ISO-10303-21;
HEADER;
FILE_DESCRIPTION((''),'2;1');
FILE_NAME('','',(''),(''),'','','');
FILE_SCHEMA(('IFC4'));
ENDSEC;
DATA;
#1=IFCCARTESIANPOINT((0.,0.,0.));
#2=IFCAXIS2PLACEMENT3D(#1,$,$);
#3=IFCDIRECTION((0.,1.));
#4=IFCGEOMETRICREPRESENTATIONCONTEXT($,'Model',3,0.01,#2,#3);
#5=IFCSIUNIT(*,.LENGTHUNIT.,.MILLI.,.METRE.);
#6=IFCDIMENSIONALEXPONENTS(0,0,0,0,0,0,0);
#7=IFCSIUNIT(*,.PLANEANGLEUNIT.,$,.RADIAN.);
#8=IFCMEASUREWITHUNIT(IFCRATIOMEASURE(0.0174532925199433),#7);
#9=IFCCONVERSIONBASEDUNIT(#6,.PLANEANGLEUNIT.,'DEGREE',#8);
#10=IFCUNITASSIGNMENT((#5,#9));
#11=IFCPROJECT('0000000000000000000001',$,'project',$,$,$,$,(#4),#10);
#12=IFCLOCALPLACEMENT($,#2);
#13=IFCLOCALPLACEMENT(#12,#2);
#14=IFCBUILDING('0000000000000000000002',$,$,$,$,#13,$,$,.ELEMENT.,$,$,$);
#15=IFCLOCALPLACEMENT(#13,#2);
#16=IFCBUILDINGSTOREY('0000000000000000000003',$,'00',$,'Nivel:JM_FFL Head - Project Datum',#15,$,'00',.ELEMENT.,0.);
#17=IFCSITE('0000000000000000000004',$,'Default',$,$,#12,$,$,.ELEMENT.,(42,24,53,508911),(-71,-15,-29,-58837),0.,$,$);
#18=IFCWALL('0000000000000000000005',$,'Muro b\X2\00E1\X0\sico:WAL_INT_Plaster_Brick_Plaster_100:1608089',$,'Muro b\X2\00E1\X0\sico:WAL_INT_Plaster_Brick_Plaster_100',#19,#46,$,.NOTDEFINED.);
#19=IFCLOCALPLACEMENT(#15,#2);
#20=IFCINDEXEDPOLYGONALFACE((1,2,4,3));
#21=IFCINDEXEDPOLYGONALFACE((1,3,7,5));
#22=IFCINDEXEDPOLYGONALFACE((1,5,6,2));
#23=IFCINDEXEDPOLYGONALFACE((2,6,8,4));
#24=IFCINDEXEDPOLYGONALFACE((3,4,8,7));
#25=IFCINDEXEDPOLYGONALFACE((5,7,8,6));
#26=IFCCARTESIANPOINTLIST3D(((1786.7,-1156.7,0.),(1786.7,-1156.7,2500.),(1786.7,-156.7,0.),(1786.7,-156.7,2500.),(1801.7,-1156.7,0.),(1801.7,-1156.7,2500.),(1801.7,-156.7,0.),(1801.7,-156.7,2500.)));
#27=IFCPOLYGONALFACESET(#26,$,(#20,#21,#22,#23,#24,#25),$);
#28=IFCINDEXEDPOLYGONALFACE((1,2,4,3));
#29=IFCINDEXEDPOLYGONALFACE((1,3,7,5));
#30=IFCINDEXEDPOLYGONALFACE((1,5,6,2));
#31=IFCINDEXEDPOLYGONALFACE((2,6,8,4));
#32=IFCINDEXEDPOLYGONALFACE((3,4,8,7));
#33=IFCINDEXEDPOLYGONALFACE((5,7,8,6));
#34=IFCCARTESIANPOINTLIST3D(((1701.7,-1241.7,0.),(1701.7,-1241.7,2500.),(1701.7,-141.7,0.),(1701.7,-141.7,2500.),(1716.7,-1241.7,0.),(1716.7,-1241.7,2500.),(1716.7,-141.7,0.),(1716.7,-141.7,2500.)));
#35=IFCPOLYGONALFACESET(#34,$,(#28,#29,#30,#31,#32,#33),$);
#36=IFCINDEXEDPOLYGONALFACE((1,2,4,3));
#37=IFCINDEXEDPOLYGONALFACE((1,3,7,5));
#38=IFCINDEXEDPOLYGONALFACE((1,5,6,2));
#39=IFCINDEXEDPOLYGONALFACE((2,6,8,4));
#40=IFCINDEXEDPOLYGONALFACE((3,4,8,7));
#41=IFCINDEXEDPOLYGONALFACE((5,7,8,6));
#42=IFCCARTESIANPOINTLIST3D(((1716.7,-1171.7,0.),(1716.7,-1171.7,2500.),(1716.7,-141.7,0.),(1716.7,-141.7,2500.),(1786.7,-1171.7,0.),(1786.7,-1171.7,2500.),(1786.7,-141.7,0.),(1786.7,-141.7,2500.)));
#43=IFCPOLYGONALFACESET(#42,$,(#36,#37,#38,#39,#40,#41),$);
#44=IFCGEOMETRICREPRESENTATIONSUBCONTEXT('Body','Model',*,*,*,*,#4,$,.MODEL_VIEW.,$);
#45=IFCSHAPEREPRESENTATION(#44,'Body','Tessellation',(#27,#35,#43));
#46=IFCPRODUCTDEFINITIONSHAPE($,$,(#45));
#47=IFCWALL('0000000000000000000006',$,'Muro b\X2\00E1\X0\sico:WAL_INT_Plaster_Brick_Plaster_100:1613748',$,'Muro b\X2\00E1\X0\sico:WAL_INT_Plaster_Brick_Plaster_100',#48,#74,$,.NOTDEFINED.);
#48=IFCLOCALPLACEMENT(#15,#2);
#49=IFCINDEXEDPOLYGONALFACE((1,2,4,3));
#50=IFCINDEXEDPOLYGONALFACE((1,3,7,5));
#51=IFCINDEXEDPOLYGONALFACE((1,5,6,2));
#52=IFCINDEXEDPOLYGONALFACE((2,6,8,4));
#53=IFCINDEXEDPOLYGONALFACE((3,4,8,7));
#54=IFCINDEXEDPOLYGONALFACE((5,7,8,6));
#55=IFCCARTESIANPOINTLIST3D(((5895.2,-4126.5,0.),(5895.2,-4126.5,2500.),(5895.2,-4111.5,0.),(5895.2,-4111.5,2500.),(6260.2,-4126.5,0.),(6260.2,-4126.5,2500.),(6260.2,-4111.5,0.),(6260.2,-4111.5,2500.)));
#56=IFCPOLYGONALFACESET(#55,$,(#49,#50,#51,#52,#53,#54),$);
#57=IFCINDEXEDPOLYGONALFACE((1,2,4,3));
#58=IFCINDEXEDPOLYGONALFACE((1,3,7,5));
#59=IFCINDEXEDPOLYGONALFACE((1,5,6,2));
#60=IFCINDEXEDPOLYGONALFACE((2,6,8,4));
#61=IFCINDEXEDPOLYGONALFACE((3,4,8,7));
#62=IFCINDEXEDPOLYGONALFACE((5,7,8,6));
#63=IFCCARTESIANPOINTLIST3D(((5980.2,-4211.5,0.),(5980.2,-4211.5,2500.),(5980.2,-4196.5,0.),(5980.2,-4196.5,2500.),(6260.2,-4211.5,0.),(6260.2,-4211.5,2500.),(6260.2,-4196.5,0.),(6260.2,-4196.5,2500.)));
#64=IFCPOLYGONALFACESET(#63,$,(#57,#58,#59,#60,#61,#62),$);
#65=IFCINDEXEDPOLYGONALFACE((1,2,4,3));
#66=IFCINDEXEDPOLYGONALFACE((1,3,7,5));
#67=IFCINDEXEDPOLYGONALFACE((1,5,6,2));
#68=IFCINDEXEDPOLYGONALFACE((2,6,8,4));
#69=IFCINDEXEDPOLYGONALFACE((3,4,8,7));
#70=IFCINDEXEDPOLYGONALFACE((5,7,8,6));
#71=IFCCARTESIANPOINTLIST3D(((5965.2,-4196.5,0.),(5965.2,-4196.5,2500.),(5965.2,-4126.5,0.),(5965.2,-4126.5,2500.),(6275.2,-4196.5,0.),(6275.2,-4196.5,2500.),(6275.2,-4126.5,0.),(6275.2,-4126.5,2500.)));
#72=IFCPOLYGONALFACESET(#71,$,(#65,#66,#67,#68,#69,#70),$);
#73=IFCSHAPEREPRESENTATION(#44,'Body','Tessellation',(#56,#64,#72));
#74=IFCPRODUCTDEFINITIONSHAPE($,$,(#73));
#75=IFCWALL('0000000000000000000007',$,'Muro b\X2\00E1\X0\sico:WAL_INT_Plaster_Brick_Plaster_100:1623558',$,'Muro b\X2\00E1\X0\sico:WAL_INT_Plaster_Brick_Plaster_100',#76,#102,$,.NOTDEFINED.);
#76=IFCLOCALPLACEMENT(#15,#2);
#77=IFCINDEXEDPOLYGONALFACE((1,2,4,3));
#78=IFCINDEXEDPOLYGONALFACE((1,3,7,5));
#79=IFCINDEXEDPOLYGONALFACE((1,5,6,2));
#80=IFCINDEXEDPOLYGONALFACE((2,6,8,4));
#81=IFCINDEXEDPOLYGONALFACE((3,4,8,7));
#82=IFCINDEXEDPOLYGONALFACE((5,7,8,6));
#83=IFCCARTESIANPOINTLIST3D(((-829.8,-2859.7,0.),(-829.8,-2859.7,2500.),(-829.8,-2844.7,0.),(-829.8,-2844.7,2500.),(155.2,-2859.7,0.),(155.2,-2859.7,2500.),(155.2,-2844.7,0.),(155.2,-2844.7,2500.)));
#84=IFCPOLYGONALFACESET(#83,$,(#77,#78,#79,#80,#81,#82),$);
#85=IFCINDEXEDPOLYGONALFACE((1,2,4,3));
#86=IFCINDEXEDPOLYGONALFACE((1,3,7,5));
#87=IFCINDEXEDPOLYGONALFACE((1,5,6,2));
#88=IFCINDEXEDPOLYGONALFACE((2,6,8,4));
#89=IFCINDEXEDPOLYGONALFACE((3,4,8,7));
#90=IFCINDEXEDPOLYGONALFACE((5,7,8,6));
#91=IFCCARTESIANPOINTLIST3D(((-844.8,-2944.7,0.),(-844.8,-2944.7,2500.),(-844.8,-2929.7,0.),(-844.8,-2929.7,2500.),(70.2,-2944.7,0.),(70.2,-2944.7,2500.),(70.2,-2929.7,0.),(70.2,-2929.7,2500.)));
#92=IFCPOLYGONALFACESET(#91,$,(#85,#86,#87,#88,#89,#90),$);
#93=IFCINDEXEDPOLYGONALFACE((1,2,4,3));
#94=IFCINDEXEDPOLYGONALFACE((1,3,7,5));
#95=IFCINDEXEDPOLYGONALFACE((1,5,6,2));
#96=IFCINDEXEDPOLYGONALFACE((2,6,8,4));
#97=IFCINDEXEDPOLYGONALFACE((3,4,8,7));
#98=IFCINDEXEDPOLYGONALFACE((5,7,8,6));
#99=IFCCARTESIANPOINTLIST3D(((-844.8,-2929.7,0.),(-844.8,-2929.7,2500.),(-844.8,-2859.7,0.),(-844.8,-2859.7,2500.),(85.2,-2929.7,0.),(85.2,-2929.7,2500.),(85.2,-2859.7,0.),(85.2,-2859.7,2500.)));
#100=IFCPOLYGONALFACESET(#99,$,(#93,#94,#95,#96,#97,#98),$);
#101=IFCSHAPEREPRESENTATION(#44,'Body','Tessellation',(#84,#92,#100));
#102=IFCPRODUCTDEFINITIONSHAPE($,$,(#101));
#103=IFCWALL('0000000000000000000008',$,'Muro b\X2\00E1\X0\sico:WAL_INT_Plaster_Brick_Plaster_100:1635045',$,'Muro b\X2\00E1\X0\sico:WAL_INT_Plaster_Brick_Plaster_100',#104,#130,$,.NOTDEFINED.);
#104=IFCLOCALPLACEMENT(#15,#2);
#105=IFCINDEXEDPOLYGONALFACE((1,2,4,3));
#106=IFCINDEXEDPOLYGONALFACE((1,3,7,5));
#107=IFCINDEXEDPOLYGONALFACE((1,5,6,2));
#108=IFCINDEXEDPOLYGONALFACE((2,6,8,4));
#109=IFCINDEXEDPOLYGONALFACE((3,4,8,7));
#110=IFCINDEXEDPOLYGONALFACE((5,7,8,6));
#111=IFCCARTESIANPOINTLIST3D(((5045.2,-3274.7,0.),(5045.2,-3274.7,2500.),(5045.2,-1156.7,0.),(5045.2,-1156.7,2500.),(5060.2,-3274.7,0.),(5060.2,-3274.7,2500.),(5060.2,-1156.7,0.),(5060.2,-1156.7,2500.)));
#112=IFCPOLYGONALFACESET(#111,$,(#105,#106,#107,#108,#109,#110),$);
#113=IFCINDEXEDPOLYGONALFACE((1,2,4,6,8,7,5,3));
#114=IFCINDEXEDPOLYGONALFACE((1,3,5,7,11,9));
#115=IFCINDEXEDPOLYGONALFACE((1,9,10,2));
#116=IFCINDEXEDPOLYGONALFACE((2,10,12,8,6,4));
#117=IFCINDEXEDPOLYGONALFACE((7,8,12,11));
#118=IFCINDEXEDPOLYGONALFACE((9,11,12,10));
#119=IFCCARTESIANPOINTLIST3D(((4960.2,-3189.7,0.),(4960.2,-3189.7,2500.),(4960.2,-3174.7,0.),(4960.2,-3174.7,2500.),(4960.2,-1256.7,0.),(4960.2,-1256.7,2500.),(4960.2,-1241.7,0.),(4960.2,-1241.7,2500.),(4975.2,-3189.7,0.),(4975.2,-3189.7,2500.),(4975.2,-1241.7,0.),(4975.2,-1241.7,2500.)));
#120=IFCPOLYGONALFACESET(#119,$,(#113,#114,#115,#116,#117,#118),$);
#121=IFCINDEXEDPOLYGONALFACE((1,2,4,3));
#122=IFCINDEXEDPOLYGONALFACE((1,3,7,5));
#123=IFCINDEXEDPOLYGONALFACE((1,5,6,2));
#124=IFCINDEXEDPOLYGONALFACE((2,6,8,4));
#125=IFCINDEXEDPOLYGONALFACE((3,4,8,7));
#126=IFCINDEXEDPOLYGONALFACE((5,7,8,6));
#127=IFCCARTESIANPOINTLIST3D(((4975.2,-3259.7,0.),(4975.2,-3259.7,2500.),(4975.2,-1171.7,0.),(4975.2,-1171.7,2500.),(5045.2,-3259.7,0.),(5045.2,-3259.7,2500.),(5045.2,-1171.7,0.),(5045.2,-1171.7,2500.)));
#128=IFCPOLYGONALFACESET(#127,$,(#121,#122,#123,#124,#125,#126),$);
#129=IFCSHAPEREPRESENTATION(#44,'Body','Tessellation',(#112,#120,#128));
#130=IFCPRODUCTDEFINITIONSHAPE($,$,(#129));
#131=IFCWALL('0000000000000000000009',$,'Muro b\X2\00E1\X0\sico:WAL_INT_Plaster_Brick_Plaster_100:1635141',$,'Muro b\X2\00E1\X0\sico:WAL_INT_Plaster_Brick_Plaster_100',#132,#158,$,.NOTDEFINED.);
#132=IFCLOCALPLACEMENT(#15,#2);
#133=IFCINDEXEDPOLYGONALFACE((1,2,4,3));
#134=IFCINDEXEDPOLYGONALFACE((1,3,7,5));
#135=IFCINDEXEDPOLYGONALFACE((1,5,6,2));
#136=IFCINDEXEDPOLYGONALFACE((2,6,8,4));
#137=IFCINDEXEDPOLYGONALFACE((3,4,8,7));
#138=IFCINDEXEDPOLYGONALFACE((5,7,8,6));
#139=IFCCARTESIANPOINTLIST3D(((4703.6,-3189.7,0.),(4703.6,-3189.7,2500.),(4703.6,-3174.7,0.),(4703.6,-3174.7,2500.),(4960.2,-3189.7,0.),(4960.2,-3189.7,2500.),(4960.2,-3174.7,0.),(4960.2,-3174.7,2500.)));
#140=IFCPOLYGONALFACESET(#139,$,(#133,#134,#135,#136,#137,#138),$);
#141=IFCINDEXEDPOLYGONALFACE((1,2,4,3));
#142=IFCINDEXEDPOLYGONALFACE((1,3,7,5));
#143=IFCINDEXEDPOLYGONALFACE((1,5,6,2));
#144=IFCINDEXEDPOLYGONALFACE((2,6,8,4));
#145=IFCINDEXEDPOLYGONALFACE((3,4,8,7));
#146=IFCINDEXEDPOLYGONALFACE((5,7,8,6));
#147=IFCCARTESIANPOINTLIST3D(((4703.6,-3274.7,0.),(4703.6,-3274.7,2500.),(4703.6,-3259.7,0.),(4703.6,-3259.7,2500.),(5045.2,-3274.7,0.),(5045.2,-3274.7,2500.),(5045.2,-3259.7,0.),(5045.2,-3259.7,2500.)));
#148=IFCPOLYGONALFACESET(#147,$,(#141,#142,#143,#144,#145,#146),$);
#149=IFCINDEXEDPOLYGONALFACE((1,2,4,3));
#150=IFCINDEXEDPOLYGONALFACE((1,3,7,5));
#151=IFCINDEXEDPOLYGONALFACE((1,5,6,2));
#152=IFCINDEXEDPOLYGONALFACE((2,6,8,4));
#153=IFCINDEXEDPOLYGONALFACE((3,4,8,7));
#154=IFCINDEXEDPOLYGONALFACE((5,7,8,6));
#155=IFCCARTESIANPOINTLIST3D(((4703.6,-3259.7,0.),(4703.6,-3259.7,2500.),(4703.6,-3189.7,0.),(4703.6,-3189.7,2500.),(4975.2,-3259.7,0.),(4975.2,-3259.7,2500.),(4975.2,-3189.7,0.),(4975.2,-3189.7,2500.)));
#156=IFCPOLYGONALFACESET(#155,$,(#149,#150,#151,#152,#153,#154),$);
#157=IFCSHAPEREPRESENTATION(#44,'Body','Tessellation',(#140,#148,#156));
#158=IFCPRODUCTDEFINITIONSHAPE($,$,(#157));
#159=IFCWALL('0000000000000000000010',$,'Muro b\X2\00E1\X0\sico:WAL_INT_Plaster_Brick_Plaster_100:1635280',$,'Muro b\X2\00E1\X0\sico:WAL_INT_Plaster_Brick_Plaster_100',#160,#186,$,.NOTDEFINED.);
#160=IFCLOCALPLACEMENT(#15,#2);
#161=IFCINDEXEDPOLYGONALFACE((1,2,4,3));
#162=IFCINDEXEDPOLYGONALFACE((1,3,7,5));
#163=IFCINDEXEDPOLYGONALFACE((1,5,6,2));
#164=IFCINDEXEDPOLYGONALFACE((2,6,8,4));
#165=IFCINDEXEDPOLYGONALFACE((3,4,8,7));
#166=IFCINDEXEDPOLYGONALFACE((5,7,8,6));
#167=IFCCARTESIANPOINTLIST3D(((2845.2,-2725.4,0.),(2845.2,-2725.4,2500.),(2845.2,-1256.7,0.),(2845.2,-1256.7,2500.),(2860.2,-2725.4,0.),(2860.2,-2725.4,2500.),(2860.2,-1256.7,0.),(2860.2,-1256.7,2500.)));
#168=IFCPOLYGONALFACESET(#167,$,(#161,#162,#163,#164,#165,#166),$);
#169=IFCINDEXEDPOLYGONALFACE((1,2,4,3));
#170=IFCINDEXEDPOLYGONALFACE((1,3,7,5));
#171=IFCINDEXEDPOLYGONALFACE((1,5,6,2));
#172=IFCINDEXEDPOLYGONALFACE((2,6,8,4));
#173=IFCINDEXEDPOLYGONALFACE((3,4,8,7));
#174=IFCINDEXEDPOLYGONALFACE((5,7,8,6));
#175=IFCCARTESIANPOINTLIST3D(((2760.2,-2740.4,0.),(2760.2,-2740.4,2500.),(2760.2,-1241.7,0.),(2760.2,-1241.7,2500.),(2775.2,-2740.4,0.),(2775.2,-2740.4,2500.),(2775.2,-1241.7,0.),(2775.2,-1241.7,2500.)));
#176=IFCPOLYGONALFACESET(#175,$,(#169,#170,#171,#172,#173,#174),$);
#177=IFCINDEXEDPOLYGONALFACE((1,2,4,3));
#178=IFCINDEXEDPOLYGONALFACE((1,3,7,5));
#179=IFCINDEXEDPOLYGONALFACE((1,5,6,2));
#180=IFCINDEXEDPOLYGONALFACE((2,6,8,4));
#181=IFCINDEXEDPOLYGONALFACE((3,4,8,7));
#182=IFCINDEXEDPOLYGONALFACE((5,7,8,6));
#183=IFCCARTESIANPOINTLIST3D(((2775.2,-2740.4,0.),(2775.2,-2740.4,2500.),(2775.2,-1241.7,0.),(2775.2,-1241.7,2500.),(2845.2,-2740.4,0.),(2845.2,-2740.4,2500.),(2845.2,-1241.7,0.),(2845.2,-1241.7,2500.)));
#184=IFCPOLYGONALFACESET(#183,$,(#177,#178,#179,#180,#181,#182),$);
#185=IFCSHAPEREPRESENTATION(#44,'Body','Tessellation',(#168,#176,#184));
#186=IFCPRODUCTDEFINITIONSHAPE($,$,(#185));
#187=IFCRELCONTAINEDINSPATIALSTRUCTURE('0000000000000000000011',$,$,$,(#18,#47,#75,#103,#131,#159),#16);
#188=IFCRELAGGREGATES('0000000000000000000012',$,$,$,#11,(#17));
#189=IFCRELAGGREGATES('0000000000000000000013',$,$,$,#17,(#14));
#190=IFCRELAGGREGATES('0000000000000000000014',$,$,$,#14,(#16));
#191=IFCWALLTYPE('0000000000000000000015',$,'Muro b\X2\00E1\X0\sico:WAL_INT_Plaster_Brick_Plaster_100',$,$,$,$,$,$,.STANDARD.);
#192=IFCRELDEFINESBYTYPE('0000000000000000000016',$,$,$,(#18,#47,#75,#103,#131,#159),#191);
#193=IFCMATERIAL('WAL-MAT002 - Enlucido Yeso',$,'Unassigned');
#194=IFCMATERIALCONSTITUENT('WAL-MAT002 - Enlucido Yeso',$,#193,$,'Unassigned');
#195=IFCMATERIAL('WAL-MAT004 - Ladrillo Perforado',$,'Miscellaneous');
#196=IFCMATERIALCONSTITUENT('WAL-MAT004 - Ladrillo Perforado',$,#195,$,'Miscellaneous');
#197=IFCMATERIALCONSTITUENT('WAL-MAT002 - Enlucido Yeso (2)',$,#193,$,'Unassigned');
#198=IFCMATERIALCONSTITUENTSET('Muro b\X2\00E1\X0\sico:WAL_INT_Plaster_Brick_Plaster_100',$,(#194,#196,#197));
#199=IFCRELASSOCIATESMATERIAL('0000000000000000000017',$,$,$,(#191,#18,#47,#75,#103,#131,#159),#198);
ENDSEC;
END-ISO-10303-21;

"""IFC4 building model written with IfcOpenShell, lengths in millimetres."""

from ifc_helpers import new_model, entity, si_unit, converted_unit, direction, frame, origin, place, context, subcontext, project, spatial, indexed_curve, outline, extrude, material, constituent, constituent_set, type_object, element, save


model = new_model("IFC4")

# Units and contexts
model_context = context("Model", 3, precision=0.01, world=origin(), true_north=direction((0.0, 1.0)))
body_context = subcontext(model_context, "Body", "Model", "MODEL_VIEW")
ifc_project = project(units=[si_unit("LENGTHUNIT", "METRE", prefix="MILLI"), converted_unit("PLANEANGLEUNIT", "DEGREE", entity("IfcRatioMeasure", 0.0174532925199433), si_unit("PLANEANGLEUNIT", "RADIAN"), dimensions=[0, 0, 0, 0, 0, 0, 0])], contexts=[model_context])

# Site, building, storey
site_placement = place(None, origin())
site = spatial("IfcSite", under=ifc_project, at=site_placement, Name="Default", CompositionType="ELEMENT", RefLatitude=(42, 24, 53, 508911), RefLongitude=(-71, -15, -29, -58837), RefElevation=0.0)
building_placement = place(site_placement, origin())
building = spatial("IfcBuilding", under=site, at=building_placement, CompositionType="ELEMENT")
storey_placement = place(building_placement, origin())
storey = spatial("IfcBuildingStorey", under=building, at=storey_placement, Name="00", ObjectType="Nivel:JM_FFL Head - Project Datum", LongName="00", CompositionType="ELEMENT", Elevation=0.0)

# Walls
ifc_material_1 = material(Name="WAL-MAT004 - Ladrillo Perforado", Category="Miscellaneous")
ifc_material_2 = material(Name="WAL-MAT002 - Enlucido Yeso", Category="Unassigned")
ifc_constituent_1 = constituent(ifc_material_2, Name="WAL-MAT002 - Enlucido Yeso", Category="Unassigned")
ifc_constituent_2 = constituent(ifc_material_1, Name="WAL-MAT004 - Ladrillo Perforado", Category="Miscellaneous")
ifc_constituent_3 = constituent(ifc_material_2, Name="WAL-MAT002 - Enlucido Yeso (2)", Category="Unassigned")
ifc_constituent_set_1 = constituent_set(constituents=[ifc_constituent_1, ifc_constituent_2, ifc_constituent_3], Name="Muro básico:WAL_INT_Plaster_Brick_Plaster_100")
wall_type_1 = type_object("IfcWallType", Name="Muro básico:WAL_INT_Plaster_Brick_Plaster_100", PredefinedType="STANDARD", material=ifc_constituent_set_1)
wall_1_placement = place(storey_placement, frame((1751.7, -1156.7, 0.0), z_axis=(0.0, 0.0, 1.0), x_axis=(0.0, 1.0, 0.0)))
element("IfcWall", 1, at=wall_1_placement, inside=storey, type_object=wall_type_1, material=ifc_constituent_set_1, Name="Muro básico:WAL_INT_Plaster_Brick_Plaster_100:1608089", ObjectType="Muro básico:WAL_INT_Plaster_Brick_Plaster_100", PredefinedType="NOTDEFINED", context=body_context, shape_type="SweptSolid", body=[
    extrude(outline(indexed_curve([(-7.5, -500.0), (7.5, -500.0), (7.5, 500.0), (-7.5, 500.0), (-7.5, -500.0)], self_intersect=False)), frame((500.0, -42.5, 0.0), z_axis=(0.0, 0.0, 1.0), x_axis=(0.0, 1.0, 0.0)), (0.0, 0.0, 1.0), 2500.0),
    extrude(outline(indexed_curve([(-7.5, -550.0), (7.5, -550.0), (7.5, 550.0), (-7.5, 550.0), (-7.5, -550.0)], self_intersect=False)), frame((465.0, 42.5, 0.0), z_axis=(0.0, 0.0, 1.0), x_axis=(0.0, -1.0, 0.0)), (0.0, 0.0, 1.0), 2500.0),
    extrude(outline(indexed_curve([(-515.0, -35.0), (515.0, -35.0), (515.0, 35.0), (-515.0, 35.0), (-515.0, -35.0)], self_intersect=False)), frame((500.0, 0.0, 0.0)), (0.0, 0.0, 1.0), 2500.0),
])
wall_2_placement = place(storey_placement, frame((5980.2, -4161.5, 0.0)))
element("IfcWall", 2, at=wall_2_placement, inside=storey, type_object=wall_type_1, material=ifc_constituent_set_1, Name="Muro básico:WAL_INT_Plaster_Brick_Plaster_100:1613748", ObjectType="Muro básico:WAL_INT_Plaster_Brick_Plaster_100", PredefinedType="NOTDEFINED", context=body_context, shape_type="SweptSolid", body=[
    extrude(outline(indexed_curve([(-7.5, -182.5), (7.5, -182.5), (7.5, 182.5), (-7.5, 182.5), (-7.5, -182.5)], self_intersect=False)), frame((97.5, 42.5, 0.0), z_axis=(0.0, 0.0, 1.0), x_axis=(0.0, -1.0, 0.0)), (0.0, 0.0, 1.0), 2500.0),
    extrude(outline(indexed_curve([(-7.5, -140.0), (7.5, -140.0), (7.5, 140.0), (-7.5, 140.0), (-7.5, -140.0)], self_intersect=False)), frame((140.0, -42.5, 0.0), z_axis=(0.0, 0.0, 1.0), x_axis=(0.0, 1.0, 0.0)), (0.0, 0.0, 1.0), 2500.0),
    extrude(outline(indexed_curve([(-155.0, -35.0), (155.0, -35.0), (155.0, 35.0), (-155.0, 35.0), (-155.0, -35.0)], self_intersect=False)), frame((140.0, 0.0, 0.0)), (0.0, 0.0, 1.0), 2500.0),
])
wall_3_placement = place(storey_placement, frame((70.2, -2894.7, 0.0), z_axis=(0.0, 0.0, 1.0), x_axis=(-1.0, 0.0, 0.0)))
element("IfcWall", 3, at=wall_3_placement, inside=storey, type_object=wall_type_1, material=ifc_constituent_set_1, Name="Muro básico:WAL_INT_Plaster_Brick_Plaster_100:1623558", ObjectType="Muro básico:WAL_INT_Plaster_Brick_Plaster_100", PredefinedType="NOTDEFINED", context=body_context, shape_type="SweptSolid", body=[
    extrude(outline(indexed_curve([(-7.5, -492.5), (7.5, -492.5), (7.5, 492.5), (-7.5, 492.5), (-7.5, -492.5)], self_intersect=False)), frame((407.5, -42.5, 0.0), z_axis=(0.0, 0.0, 1.0), x_axis=(0.0, 1.0, 0.0)), (0.0, 0.0, 1.0), 2500.0),
    extrude(outline(indexed_curve([(-7.5, -457.5), (7.5, -457.5), (7.5, 457.5), (-7.5, 457.5), (-7.5, -457.5)], self_intersect=False)), frame((457.5, 42.5, 0.0), z_axis=(0.0, 0.0, 1.0), x_axis=(0.0, -1.0, 0.0)), (0.0, 0.0, 1.0), 2500.0),
    extrude(outline(indexed_curve([(-465.0, -35.0), (465.0, -35.0), (465.0, 35.0), (-465.0, 35.0), (-465.0, -35.0)], self_intersect=False)), frame((450.0, 0.0, 0.0)), (0.0, 0.0, 1.0), 2500.0),
])
wall_4_placement = place(storey_placement, frame((5010.2, -3274.7, 0.0), z_axis=(0.0, 0.0, 1.0), x_axis=(0.0, 1.0, 0.0)))
element("IfcWall", 4, at=wall_4_placement, inside=storey, type_object=wall_type_1, material=ifc_constituent_set_1, Name="Muro básico:WAL_INT_Plaster_Brick_Plaster_100:1635045", ObjectType="Muro básico:WAL_INT_Plaster_Brick_Plaster_100", PredefinedType="NOTDEFINED", context=body_context, shape_type="SweptSolid", body=[
    extrude(outline(indexed_curve([(-7.5, -1059.0), (7.5, -1059.0), (7.5, 1059.0), (-7.5, 1059.0), (-7.5, -1059.0)], self_intersect=False)), frame((1059.0, -42.5, 0.0), z_axis=(0.0, 0.0, 1.0), x_axis=(0.0, 1.0, 0.0)), (0.0, 0.0, 1.0), 2500.0),
    extrude(outline(indexed_curve([(-959.0, -5.0), (959.0, -5.0), (974.0, -5.0), (974.0, 10.0), (-974.0, 10.0), (-974.0, -5.0), (-959.0, -5.0)], self_intersect=False)), frame((1059.0, 45.0, 0.0), z_axis=(0.0, 0.0, 1.0), x_axis=(-1.0, 0.0, 0.0)), (0.0, 0.0, 1.0), 2500.0),
    extrude(outline(indexed_curve([(-1044.0, -35.0), (1044.0, -35.0), (1044.0, 35.0), (-1044.0, 35.0), (-1044.0, -35.0)], self_intersect=False)), frame((1059.0, 0.0, 0.0)), (0.0, 0.0, 1.0), 2500.0),
])
wall_5_placement = place(storey_placement, frame((4703.6, -3224.7, 0.0)))
element("IfcWall", 5, at=wall_5_placement, inside=storey, type_object=wall_type_1, material=ifc_constituent_set_1, Name="Muro básico:WAL_INT_Plaster_Brick_Plaster_100:1635141", ObjectType="Muro básico:WAL_INT_Plaster_Brick_Plaster_100", PredefinedType="NOTDEFINED", context=body_context, shape_type="SweptSolid", body=[
    extrude(outline(indexed_curve([(-7.5, -128.3), (7.5, -128.3), (7.5, 128.3), (-7.5, 128.3), (-7.5, -128.3)], self_intersect=False)), frame((128.3, 42.5, 0.0), z_axis=(0.0, 0.0, 1.0), x_axis=(0.0, -1.0, 0.0)), (0.0, 0.0, 1.0), 2500.0),
    extrude(outline(indexed_curve([(-7.5, -170.8), (7.5, -170.8), (7.5, 170.8), (-7.5, 170.8), (-7.5, -170.8)], self_intersect=False)), frame((170.8, -42.5, 0.0), z_axis=(0.0, 0.0, 1.0), x_axis=(0.0, 1.0, 0.0)), (0.0, 0.0, 1.0), 2500.0),
    extrude(outline(indexed_curve([(-135.8, -35.0), (135.8, -35.0), (135.8, 35.0), (-135.8, 35.0), (-135.8, -35.0)], self_intersect=False)), frame((135.8, 0.0, 0.0)), (0.0, 0.0, 1.0), 2500.0),
])
wall_6_placement = place(storey_placement, frame((2810.2, -2725.4, 0.0), z_axis=(0.0, 0.0, 1.0), x_axis=(0.0, 1.0, 0.0)))
element("IfcWall", 6, at=wall_6_placement, inside=storey, type_object=wall_type_1, material=ifc_constituent_set_1, Name="Muro básico:WAL_INT_Plaster_Brick_Plaster_100:1635280", ObjectType="Muro básico:WAL_INT_Plaster_Brick_Plaster_100", PredefinedType="NOTDEFINED", context=body_context, shape_type="SweptSolid", body=[
    extrude(outline(indexed_curve([(-7.5, -734.4), (7.5, -734.4), (7.5, 734.4), (-7.5, 734.4), (-7.5, -734.4)], self_intersect=False)), frame((734.4, -42.5, 0.0), z_axis=(0.0, 0.0, 1.0), x_axis=(0.0, 1.0, 0.0)), (0.0, 0.0, 1.0), 2500.0),
    extrude(outline(indexed_curve([(-7.5, -749.4), (7.5, -749.4), (7.5, 749.4), (-7.5, 749.4), (-7.5, -749.4)], self_intersect=False)), frame((734.4, 42.5, 0.0), z_axis=(0.0, 0.0, 1.0), x_axis=(0.0, -1.0, 0.0)), (0.0, 0.0, 1.0), 2500.0),
    extrude(outline(indexed_curve([(-749.4, -35.0), (749.4, -35.0), (749.4, 35.0), (-749.4, 35.0), (-749.4, -35.0)], self_intersect=False)), frame((734.4, 0.0, 0.0)), (0.0, 0.0, 1.0), 2500.0),
])

save(model, "model.ifc")
